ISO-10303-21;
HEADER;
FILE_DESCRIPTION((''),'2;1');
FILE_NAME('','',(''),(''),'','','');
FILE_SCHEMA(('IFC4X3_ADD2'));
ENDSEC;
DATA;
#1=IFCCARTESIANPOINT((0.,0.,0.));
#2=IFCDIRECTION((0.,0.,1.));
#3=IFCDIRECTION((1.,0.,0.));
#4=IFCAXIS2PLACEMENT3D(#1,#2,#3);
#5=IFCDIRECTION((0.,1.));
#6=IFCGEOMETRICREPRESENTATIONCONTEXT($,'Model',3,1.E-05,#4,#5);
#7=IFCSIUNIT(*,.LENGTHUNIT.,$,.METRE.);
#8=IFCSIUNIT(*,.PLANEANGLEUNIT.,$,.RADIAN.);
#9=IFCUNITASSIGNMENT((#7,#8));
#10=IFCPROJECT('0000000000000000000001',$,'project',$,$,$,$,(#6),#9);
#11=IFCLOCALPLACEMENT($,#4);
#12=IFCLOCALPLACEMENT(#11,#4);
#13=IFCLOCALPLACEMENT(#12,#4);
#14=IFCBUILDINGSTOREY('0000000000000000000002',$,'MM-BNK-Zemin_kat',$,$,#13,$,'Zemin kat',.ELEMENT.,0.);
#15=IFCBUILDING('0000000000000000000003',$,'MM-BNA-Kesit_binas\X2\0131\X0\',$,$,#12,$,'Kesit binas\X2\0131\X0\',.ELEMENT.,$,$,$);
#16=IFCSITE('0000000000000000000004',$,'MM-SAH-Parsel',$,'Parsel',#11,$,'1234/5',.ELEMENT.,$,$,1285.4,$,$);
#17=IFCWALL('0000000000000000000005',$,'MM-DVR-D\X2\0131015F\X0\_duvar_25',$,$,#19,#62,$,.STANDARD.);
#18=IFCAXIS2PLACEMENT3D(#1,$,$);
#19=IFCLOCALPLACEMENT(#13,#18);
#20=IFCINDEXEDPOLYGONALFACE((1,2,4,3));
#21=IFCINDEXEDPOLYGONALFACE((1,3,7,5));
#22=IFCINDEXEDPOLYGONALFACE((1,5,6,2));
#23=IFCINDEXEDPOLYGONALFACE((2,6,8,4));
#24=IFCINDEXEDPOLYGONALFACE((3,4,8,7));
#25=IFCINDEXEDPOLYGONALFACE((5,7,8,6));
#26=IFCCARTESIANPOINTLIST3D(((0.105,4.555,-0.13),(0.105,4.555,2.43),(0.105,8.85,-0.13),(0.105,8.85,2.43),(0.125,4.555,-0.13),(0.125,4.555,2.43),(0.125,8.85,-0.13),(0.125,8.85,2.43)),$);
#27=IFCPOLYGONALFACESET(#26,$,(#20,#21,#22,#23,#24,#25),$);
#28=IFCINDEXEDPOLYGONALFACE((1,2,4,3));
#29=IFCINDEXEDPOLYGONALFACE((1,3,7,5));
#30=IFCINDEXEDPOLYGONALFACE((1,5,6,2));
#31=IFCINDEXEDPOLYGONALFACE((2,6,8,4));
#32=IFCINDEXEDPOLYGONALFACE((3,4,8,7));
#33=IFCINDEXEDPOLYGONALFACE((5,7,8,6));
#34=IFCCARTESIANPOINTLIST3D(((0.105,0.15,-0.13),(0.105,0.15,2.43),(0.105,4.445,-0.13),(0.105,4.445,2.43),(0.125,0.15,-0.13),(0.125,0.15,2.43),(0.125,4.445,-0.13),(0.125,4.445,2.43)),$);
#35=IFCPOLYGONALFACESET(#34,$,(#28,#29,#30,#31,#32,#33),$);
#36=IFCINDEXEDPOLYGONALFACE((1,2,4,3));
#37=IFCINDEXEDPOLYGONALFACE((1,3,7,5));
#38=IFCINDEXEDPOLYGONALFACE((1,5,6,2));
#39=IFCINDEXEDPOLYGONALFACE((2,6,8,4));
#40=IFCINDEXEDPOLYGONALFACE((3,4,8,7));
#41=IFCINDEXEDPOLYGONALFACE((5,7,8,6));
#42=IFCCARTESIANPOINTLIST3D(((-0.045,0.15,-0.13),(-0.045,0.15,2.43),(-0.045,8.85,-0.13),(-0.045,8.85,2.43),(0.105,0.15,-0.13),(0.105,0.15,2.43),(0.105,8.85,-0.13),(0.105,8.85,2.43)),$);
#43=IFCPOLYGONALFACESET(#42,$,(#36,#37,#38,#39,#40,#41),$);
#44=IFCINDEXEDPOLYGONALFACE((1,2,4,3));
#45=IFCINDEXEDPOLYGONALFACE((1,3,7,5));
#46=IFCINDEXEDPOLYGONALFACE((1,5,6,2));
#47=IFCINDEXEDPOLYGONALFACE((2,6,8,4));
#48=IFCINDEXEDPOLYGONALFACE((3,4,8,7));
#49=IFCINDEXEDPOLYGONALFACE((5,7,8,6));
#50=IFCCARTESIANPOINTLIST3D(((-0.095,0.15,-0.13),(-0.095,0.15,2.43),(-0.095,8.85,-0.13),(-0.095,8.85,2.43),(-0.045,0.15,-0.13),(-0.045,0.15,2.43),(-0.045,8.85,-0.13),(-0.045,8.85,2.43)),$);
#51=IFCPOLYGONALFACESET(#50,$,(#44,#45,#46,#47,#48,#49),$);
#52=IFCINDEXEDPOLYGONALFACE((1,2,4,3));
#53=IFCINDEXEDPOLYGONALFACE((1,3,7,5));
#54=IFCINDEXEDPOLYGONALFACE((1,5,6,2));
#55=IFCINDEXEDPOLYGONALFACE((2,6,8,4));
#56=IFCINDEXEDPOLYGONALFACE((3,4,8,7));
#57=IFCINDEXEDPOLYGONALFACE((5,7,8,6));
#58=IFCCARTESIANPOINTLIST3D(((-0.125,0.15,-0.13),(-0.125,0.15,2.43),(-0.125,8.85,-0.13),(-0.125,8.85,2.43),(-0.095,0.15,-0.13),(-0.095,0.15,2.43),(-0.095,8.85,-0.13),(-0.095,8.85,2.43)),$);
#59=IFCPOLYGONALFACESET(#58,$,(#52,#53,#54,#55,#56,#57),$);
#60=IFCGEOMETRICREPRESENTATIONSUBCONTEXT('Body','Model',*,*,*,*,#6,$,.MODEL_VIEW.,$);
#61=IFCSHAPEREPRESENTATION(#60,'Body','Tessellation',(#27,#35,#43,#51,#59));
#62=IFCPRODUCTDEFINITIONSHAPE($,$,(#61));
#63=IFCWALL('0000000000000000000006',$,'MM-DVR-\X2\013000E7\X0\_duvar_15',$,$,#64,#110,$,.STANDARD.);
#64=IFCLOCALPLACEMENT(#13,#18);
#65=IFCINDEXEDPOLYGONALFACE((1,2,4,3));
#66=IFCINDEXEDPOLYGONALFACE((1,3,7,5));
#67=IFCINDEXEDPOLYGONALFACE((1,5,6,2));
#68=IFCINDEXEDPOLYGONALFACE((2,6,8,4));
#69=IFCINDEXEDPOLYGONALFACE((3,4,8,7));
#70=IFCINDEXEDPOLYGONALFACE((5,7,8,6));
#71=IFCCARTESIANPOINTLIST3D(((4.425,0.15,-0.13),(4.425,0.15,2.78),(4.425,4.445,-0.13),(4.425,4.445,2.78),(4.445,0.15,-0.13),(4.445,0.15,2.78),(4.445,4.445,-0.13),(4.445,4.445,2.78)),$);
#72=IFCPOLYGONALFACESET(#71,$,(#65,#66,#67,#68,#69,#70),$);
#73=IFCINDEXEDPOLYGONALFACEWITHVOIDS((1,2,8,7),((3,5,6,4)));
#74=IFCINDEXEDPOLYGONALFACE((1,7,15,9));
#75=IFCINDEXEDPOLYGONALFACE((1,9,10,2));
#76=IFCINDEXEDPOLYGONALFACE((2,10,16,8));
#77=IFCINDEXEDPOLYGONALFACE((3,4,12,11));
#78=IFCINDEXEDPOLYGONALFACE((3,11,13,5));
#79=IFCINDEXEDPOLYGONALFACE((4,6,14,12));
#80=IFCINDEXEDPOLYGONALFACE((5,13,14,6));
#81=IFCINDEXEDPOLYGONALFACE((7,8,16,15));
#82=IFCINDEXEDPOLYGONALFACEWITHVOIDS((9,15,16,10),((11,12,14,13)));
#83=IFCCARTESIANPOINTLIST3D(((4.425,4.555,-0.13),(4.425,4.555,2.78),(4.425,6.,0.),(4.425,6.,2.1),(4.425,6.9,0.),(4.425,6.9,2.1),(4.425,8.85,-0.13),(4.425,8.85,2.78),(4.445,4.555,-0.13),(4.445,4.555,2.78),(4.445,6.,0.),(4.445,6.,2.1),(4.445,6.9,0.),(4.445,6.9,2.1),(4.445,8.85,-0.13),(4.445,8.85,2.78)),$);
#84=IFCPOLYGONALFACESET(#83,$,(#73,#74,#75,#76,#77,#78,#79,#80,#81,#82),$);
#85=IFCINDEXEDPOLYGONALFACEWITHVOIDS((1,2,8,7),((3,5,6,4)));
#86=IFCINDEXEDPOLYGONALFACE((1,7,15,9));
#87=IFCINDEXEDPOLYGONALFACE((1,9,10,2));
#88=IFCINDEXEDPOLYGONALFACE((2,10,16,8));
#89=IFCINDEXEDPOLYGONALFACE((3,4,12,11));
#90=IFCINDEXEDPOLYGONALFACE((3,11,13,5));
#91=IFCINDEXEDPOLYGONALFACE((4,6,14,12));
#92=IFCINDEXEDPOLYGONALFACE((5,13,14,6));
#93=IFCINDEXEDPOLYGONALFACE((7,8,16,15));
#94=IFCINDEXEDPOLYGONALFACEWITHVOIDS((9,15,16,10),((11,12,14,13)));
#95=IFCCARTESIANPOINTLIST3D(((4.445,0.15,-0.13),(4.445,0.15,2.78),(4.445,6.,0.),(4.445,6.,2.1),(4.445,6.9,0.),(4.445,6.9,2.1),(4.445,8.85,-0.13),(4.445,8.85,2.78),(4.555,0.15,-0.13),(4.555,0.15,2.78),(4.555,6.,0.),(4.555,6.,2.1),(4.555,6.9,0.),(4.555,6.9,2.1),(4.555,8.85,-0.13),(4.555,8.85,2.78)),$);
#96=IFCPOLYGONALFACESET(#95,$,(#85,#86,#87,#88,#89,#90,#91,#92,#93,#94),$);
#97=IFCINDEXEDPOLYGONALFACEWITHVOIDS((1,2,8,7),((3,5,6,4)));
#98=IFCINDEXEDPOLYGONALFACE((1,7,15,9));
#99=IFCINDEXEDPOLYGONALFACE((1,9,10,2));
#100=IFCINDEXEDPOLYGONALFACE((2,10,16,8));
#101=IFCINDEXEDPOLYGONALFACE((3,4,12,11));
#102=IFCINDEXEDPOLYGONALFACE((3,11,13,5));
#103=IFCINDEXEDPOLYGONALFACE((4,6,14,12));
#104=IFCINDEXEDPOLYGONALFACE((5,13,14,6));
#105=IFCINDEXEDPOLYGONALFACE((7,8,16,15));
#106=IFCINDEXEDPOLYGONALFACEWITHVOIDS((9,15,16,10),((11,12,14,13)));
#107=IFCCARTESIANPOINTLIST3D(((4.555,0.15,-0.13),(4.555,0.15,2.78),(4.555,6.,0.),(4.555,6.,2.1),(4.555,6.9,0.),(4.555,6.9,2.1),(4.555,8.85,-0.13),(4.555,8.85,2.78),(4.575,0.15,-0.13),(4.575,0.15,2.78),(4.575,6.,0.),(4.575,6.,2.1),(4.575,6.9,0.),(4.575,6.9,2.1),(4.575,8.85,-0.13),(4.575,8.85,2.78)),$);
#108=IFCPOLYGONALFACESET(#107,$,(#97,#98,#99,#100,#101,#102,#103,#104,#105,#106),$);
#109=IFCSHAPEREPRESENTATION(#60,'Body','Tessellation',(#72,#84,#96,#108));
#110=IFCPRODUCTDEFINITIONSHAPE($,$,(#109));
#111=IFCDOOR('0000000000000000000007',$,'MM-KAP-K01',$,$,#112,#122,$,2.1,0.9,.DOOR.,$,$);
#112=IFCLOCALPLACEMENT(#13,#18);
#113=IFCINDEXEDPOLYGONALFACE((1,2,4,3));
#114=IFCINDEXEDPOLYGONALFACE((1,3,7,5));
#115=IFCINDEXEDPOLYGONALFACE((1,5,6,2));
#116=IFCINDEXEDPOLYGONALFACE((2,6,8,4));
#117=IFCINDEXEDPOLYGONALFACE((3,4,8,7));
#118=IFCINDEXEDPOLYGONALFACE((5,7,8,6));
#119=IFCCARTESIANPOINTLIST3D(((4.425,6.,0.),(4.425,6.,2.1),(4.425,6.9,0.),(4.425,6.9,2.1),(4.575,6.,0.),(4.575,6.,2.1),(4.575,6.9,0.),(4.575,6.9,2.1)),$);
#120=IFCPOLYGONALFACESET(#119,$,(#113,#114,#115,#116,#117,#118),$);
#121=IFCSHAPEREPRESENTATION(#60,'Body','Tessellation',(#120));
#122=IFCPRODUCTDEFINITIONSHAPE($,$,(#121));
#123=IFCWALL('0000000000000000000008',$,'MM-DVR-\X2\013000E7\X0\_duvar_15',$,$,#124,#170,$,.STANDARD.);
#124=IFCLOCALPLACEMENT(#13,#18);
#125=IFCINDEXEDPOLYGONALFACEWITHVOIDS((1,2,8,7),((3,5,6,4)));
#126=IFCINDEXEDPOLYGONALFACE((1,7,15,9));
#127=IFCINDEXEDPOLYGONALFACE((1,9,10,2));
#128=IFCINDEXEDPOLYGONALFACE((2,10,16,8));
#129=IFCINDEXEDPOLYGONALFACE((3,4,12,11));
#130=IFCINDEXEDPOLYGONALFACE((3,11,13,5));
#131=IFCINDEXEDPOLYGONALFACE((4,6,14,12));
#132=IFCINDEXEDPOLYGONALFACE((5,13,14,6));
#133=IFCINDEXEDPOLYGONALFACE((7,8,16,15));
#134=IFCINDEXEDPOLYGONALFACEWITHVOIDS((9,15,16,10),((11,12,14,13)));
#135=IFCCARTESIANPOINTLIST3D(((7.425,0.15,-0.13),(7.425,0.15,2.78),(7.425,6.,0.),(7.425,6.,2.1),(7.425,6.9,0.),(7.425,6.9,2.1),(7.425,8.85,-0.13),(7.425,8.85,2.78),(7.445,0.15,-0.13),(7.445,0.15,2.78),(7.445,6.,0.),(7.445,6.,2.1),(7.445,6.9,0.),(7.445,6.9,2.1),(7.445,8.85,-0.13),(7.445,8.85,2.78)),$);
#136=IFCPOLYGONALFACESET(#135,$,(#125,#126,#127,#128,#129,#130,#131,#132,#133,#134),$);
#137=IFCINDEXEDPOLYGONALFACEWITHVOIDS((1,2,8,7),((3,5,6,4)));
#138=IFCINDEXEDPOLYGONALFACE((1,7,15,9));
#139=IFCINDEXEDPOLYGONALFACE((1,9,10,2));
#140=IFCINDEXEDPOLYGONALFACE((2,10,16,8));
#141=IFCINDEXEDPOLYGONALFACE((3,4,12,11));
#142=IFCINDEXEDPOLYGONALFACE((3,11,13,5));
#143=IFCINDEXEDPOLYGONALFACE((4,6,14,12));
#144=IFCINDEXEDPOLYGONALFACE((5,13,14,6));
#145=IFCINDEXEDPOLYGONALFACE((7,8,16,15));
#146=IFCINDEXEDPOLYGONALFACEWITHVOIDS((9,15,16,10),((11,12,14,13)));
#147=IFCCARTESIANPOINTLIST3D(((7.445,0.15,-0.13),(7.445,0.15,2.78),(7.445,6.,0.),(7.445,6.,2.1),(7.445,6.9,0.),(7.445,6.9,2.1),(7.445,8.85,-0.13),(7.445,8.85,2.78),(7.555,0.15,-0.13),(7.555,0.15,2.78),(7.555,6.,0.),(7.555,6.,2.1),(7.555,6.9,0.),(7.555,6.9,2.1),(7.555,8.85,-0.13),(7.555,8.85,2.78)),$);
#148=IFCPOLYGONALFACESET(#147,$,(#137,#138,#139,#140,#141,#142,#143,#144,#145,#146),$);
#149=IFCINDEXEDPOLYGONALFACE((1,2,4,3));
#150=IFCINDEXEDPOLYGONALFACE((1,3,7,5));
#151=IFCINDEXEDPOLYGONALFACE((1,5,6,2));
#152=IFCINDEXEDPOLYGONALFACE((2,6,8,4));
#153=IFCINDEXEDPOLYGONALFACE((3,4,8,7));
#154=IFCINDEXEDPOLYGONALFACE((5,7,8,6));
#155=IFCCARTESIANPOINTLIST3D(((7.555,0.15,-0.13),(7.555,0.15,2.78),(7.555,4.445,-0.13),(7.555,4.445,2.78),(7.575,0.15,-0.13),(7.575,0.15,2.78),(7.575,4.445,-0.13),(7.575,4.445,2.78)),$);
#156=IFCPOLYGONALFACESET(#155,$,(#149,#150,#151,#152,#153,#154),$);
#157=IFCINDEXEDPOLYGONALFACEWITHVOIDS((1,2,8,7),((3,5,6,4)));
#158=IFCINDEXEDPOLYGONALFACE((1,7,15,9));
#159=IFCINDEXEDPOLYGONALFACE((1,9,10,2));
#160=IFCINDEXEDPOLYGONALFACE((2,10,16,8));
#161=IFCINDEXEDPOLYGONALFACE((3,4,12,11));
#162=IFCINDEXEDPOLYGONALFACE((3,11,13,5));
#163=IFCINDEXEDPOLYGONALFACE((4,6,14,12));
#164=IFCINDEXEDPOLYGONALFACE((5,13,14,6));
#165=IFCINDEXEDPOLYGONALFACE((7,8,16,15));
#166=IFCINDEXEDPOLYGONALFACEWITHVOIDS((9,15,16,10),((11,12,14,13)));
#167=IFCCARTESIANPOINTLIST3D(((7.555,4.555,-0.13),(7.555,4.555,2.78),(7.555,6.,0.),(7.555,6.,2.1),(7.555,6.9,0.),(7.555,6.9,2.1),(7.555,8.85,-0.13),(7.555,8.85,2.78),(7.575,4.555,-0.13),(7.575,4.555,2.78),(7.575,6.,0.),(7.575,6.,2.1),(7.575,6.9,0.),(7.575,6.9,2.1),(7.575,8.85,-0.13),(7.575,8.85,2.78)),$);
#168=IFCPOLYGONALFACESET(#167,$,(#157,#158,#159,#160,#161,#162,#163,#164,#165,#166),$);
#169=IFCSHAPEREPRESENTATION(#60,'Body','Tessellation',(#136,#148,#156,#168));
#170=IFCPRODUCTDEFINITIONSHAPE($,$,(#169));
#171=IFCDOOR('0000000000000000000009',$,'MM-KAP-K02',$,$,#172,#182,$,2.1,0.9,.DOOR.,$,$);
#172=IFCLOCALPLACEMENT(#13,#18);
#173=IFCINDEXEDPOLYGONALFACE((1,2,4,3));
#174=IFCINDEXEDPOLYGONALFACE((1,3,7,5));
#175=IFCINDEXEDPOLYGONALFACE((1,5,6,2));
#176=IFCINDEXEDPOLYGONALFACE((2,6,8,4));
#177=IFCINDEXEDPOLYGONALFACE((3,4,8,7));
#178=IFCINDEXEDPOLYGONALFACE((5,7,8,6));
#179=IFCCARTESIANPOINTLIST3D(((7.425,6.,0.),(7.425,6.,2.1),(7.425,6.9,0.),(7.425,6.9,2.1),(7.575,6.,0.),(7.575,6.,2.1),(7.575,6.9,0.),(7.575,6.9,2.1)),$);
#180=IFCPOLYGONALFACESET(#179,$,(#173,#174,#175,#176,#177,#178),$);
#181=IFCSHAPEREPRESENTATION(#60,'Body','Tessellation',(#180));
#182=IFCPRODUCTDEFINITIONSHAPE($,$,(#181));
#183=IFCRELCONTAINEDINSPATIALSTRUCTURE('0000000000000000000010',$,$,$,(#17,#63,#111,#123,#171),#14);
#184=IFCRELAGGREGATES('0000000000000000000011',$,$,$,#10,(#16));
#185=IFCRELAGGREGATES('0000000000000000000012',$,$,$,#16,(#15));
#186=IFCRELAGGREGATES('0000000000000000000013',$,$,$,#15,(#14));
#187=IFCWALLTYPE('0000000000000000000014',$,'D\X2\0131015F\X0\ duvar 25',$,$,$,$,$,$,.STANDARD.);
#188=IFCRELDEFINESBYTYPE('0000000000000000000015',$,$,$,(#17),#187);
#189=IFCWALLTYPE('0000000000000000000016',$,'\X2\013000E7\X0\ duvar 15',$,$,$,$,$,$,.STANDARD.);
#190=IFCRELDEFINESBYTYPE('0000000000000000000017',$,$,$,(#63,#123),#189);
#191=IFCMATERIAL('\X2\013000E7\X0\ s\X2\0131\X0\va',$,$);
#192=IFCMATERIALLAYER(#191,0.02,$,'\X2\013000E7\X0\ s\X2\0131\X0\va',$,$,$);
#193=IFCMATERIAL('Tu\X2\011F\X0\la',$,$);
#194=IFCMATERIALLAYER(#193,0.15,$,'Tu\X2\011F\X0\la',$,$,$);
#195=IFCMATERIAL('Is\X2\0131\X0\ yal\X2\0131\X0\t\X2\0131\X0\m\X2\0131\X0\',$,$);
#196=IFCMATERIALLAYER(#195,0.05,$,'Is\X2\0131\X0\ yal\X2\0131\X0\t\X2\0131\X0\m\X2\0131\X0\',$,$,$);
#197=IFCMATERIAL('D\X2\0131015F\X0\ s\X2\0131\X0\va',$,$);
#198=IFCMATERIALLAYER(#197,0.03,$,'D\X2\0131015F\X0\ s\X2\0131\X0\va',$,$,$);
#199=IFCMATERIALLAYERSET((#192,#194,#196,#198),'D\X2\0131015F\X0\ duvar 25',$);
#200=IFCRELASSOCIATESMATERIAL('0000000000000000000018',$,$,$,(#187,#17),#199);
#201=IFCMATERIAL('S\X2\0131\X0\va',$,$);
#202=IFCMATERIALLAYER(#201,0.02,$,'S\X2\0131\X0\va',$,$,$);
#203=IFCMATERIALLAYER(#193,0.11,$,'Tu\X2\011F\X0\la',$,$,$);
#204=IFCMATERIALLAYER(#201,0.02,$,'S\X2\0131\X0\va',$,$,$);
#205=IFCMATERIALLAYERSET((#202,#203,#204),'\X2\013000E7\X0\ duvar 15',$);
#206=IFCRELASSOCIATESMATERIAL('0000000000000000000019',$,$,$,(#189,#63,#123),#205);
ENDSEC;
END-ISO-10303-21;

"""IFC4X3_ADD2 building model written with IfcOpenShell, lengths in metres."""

from ifc_helpers import new_model, si_unit, direction, frame, origin, origin_with_axes, place, context, subcontext, project, spatial, polyline, outline, extrude, material, layer, layer_set, type_object, element, fill, save


model = new_model("IFC4X3_ADD2")

# Units and contexts
model_context = context("Model", 3, precision=1e-05, world=origin_with_axes(), true_north=direction((0.0, 1.0)))
body_context = subcontext(model_context, "Body", "Model", "MODEL_VIEW")
ifc_project = project(units=[si_unit("LENGTHUNIT", "METRE"), si_unit("PLANEANGLEUNIT", "RADIAN")], contexts=[model_context])

# Site, building, storey
site_placement = place(None, origin_with_axes())
site = spatial("IfcSite", under=ifc_project, at=site_placement, Name="MM-SAH-Parsel", ObjectType="Parsel", LongName="1234/5", CompositionType="ELEMENT", RefElevation=1285.4)
building_placement = place(site_placement, origin_with_axes())
building = spatial("IfcBuilding", under=site, at=building_placement, Name="MM-BNA-Kesit_binası", LongName="Kesit binası", CompositionType="ELEMENT")
storey_placement = place(building_placement, origin_with_axes())
storey = spatial("IfcBuildingStorey", under=building, at=storey_placement, Name="MM-BNK-Zemin_kat", LongName="Zemin kat", CompositionType="ELEMENT", Elevation=0.0)

# Shared definitions
ifc_material_1 = material(Name="İç sıva")
ifc_layer_1 = layer(ifc_material_1, 0.02, Name="İç sıva")
ifc_material_2 = material(Name="Tuğla")
ifc_layer_2 = layer(ifc_material_2, 0.15, Name="Tuğla")
ifc_material_3 = material(Name="Isı yalıtımı")
ifc_layer_3 = layer(ifc_material_3, 0.05, Name="Isı yalıtımı")
ifc_material_4 = material(Name="Dış sıva")
ifc_layer_4 = layer(ifc_material_4, 0.03, Name="Dış sıva")
ifc_layer_set_1 = layer_set([ifc_layer_1, ifc_layer_2, ifc_layer_3, ifc_layer_4], Name="Dış duvar 25")
wall_type_1 = type_object("IfcWallType", Name="Dış duvar 25", PredefinedType="STANDARD", material=ifc_layer_set_1)

# Wall
wall_1_placement = place(storey_placement, origin_with_axes())
element("IfcWall", 1, at=wall_1_placement, inside=storey, type_object=wall_type_1, material=ifc_layer_set_1, Name="MM-DVR-Dış_duvar_25", PredefinedType="STANDARD", context=body_context, shape_type="SweptSolid", body=[
    extrude(outline(polyline([(0.105, 8.85), (0.105, 4.555), (0.125, 4.555), (0.125, 8.85), (0.105, 8.85)])), frame((0.0, 0.0, -0.13)), (0.0, 0.0, 1.0), 2.56),
    extrude(outline(polyline([(0.105, 4.445), (0.105, 0.15), (0.125, 0.15), (0.125, 4.445), (0.105, 4.445)])), frame((0.0, 0.0, -0.13)), (0.0, 0.0, 1.0), 2.56),
    extrude(outline(polyline([(-0.045, 8.85), (-0.045, 0.15), (0.105, 0.15), (0.105, 8.85), (-0.045, 8.85)])), frame((0.0, 0.0, -0.13)), (0.0, 0.0, 1.0), 2.56),
    extrude(outline(polyline([(-0.095, 8.85), (-0.095, 0.15), (-0.045, 0.15), (-0.045, 8.85), (-0.095, 8.85)])), frame((0.0, 0.0, -0.13)), (0.0, 0.0, 1.0), 2.56),
    extrude(outline(polyline([(-0.125, 8.85), (-0.125, 0.15), (-0.095, 0.15), (-0.095, 8.85), (-0.125, 8.85)])), frame((0.0, 0.0, -0.13)), (0.0, 0.0, 1.0), 2.56),
])

# Walls, openings, doors
ifc_material_5 = material(Name="Sıva")
ifc_layer_5 = layer(ifc_material_5, 0.02, Name="Sıva")
ifc_layer_6 = layer(ifc_material_2, 0.11, Name="Tuğla")
ifc_layer_7 = layer(ifc_material_5, 0.02, Name="Sıva")
ifc_layer_set_2 = layer_set([ifc_layer_5, ifc_layer_6, ifc_layer_7], Name="İç duvar 15")
wall_type_2 = type_object("IfcWallType", Name="İç duvar 15", PredefinedType="STANDARD", material=ifc_layer_set_2)
wall_2_placement = place(storey_placement, origin_with_axes())
wall_2 = element("IfcWall", 2, at=wall_2_placement, inside=storey, type_object=wall_type_2, material=ifc_layer_set_2, Name="MM-DVR-İç_duvar_15", PredefinedType="STANDARD", context=body_context, shape_type="SweptSolid", body=[
    extrude(outline(polyline([(4.445, 0.15), (4.445, 4.445), (4.425, 4.445), (4.425, 0.15), (4.445, 0.15)])), frame((0.0, 0.0, -0.13)), (0.0, 0.0, 1.0), 2.91),
    extrude(outline(polyline([(4.445, 4.555), (4.445, 8.85), (4.425, 8.85), (4.425, 4.555), (4.445, 4.555)])), frame((0.0, 0.0, -0.13)), (0.0, 0.0, 1.0), 2.91),
    extrude(outline(polyline([(4.555, 0.15), (4.555, 8.85), (4.445, 8.85), (4.445, 0.15), (4.555, 0.15)])), frame((0.0, 0.0, -0.13)), (0.0, 0.0, 1.0), 2.91),
    extrude(outline(polyline([(4.575, 0.15), (4.575, 8.85), (4.555, 8.85), (4.555, 0.15), (4.575, 0.15)])), frame((0.0, 0.0, -0.13)), (0.0, 0.0, 1.0), 2.91),
])
opening_1_placement = place(storey_placement, origin_with_axes())
opening_1 = element("IfcOpeningElement", 3, at=opening_1_placement, cuts=wall_2, PredefinedType="OPENING", context=body_context, shape_type="SweptSolid", body=[
    extrude(outline(polyline([(4.425, 6.0), (4.425, 6.9), (4.575, 6.9), (4.575, 6.0), (4.425, 6.0)])), origin(), (0.0, 0.0, 1.0), 2.1),
])
door_1_placement = place(storey_placement, origin_with_axes())
door_1 = element("IfcDoor", 4, at=door_1_placement, inside=storey, Name="MM-KAP-K01", OverallHeight=2.1, OverallWidth=0.9, PredefinedType="DOOR", context=body_context, shape_type="SweptSolid", body=[
    extrude(outline(polyline([(4.425, 6.0), (4.425, 6.9), (4.575, 6.9), (4.575, 6.0), (4.425, 6.0)])), origin(), (0.0, 0.0, 1.0), 2.1),
])
fill(opening_1, door_1)
wall_3_placement = place(storey_placement, origin_with_axes())
wall_3 = element("IfcWall", 5, at=wall_3_placement, inside=storey, type_object=wall_type_2, material=ifc_layer_set_2, Name="MM-DVR-İç_duvar_15", PredefinedType="STANDARD", context=body_context, shape_type="SweptSolid", body=[
    extrude(outline(polyline([(7.445, 0.15), (7.445, 8.85), (7.425, 8.85), (7.425, 0.15), (7.445, 0.15)])), frame((0.0, 0.0, -0.13)), (0.0, 0.0, 1.0), 2.91),
    extrude(outline(polyline([(7.555, 0.15), (7.555, 8.85), (7.445, 8.85), (7.445, 0.15), (7.555, 0.15)])), frame((0.0, 0.0, -0.13)), (0.0, 0.0, 1.0), 2.91),
    extrude(outline(polyline([(7.575, 0.15), (7.575, 4.445), (7.555, 4.445), (7.555, 0.15), (7.575, 0.15)])), frame((0.0, 0.0, -0.13)), (0.0, 0.0, 1.0), 2.91),
    extrude(outline(polyline([(7.575, 4.555), (7.575, 8.85), (7.555, 8.85), (7.555, 4.555), (7.575, 4.555)])), frame((0.0, 0.0, -0.13)), (0.0, 0.0, 1.0), 2.91),
])
opening_2_placement = place(storey_placement, origin_with_axes())
opening_2 = element("IfcOpeningElement", 6, at=opening_2_placement, cuts=wall_3, PredefinedType="OPENING", context=body_context, shape_type="SweptSolid", body=[
    extrude(outline(polyline([(7.425, 6.0), (7.425, 6.9), (7.575, 6.9), (7.575, 6.0), (7.425, 6.0)])), origin(), (0.0, 0.0, 1.0), 2.1),
])
door_2_placement = place(storey_placement, origin_with_axes())
door_2 = element("IfcDoor", 7, at=door_2_placement, inside=storey, Name="MM-KAP-K02", OverallHeight=2.1, OverallWidth=0.9, PredefinedType="DOOR", context=body_context, shape_type="SweptSolid", body=[
    extrude(outline(polyline([(7.425, 6.0), (7.425, 6.9), (7.575, 6.9), (7.575, 6.0), (7.425, 6.0)])), origin(), (0.0, 0.0, 1.0), 2.1),
])
fill(opening_2, door_2)

save(model, "model.ifc")
